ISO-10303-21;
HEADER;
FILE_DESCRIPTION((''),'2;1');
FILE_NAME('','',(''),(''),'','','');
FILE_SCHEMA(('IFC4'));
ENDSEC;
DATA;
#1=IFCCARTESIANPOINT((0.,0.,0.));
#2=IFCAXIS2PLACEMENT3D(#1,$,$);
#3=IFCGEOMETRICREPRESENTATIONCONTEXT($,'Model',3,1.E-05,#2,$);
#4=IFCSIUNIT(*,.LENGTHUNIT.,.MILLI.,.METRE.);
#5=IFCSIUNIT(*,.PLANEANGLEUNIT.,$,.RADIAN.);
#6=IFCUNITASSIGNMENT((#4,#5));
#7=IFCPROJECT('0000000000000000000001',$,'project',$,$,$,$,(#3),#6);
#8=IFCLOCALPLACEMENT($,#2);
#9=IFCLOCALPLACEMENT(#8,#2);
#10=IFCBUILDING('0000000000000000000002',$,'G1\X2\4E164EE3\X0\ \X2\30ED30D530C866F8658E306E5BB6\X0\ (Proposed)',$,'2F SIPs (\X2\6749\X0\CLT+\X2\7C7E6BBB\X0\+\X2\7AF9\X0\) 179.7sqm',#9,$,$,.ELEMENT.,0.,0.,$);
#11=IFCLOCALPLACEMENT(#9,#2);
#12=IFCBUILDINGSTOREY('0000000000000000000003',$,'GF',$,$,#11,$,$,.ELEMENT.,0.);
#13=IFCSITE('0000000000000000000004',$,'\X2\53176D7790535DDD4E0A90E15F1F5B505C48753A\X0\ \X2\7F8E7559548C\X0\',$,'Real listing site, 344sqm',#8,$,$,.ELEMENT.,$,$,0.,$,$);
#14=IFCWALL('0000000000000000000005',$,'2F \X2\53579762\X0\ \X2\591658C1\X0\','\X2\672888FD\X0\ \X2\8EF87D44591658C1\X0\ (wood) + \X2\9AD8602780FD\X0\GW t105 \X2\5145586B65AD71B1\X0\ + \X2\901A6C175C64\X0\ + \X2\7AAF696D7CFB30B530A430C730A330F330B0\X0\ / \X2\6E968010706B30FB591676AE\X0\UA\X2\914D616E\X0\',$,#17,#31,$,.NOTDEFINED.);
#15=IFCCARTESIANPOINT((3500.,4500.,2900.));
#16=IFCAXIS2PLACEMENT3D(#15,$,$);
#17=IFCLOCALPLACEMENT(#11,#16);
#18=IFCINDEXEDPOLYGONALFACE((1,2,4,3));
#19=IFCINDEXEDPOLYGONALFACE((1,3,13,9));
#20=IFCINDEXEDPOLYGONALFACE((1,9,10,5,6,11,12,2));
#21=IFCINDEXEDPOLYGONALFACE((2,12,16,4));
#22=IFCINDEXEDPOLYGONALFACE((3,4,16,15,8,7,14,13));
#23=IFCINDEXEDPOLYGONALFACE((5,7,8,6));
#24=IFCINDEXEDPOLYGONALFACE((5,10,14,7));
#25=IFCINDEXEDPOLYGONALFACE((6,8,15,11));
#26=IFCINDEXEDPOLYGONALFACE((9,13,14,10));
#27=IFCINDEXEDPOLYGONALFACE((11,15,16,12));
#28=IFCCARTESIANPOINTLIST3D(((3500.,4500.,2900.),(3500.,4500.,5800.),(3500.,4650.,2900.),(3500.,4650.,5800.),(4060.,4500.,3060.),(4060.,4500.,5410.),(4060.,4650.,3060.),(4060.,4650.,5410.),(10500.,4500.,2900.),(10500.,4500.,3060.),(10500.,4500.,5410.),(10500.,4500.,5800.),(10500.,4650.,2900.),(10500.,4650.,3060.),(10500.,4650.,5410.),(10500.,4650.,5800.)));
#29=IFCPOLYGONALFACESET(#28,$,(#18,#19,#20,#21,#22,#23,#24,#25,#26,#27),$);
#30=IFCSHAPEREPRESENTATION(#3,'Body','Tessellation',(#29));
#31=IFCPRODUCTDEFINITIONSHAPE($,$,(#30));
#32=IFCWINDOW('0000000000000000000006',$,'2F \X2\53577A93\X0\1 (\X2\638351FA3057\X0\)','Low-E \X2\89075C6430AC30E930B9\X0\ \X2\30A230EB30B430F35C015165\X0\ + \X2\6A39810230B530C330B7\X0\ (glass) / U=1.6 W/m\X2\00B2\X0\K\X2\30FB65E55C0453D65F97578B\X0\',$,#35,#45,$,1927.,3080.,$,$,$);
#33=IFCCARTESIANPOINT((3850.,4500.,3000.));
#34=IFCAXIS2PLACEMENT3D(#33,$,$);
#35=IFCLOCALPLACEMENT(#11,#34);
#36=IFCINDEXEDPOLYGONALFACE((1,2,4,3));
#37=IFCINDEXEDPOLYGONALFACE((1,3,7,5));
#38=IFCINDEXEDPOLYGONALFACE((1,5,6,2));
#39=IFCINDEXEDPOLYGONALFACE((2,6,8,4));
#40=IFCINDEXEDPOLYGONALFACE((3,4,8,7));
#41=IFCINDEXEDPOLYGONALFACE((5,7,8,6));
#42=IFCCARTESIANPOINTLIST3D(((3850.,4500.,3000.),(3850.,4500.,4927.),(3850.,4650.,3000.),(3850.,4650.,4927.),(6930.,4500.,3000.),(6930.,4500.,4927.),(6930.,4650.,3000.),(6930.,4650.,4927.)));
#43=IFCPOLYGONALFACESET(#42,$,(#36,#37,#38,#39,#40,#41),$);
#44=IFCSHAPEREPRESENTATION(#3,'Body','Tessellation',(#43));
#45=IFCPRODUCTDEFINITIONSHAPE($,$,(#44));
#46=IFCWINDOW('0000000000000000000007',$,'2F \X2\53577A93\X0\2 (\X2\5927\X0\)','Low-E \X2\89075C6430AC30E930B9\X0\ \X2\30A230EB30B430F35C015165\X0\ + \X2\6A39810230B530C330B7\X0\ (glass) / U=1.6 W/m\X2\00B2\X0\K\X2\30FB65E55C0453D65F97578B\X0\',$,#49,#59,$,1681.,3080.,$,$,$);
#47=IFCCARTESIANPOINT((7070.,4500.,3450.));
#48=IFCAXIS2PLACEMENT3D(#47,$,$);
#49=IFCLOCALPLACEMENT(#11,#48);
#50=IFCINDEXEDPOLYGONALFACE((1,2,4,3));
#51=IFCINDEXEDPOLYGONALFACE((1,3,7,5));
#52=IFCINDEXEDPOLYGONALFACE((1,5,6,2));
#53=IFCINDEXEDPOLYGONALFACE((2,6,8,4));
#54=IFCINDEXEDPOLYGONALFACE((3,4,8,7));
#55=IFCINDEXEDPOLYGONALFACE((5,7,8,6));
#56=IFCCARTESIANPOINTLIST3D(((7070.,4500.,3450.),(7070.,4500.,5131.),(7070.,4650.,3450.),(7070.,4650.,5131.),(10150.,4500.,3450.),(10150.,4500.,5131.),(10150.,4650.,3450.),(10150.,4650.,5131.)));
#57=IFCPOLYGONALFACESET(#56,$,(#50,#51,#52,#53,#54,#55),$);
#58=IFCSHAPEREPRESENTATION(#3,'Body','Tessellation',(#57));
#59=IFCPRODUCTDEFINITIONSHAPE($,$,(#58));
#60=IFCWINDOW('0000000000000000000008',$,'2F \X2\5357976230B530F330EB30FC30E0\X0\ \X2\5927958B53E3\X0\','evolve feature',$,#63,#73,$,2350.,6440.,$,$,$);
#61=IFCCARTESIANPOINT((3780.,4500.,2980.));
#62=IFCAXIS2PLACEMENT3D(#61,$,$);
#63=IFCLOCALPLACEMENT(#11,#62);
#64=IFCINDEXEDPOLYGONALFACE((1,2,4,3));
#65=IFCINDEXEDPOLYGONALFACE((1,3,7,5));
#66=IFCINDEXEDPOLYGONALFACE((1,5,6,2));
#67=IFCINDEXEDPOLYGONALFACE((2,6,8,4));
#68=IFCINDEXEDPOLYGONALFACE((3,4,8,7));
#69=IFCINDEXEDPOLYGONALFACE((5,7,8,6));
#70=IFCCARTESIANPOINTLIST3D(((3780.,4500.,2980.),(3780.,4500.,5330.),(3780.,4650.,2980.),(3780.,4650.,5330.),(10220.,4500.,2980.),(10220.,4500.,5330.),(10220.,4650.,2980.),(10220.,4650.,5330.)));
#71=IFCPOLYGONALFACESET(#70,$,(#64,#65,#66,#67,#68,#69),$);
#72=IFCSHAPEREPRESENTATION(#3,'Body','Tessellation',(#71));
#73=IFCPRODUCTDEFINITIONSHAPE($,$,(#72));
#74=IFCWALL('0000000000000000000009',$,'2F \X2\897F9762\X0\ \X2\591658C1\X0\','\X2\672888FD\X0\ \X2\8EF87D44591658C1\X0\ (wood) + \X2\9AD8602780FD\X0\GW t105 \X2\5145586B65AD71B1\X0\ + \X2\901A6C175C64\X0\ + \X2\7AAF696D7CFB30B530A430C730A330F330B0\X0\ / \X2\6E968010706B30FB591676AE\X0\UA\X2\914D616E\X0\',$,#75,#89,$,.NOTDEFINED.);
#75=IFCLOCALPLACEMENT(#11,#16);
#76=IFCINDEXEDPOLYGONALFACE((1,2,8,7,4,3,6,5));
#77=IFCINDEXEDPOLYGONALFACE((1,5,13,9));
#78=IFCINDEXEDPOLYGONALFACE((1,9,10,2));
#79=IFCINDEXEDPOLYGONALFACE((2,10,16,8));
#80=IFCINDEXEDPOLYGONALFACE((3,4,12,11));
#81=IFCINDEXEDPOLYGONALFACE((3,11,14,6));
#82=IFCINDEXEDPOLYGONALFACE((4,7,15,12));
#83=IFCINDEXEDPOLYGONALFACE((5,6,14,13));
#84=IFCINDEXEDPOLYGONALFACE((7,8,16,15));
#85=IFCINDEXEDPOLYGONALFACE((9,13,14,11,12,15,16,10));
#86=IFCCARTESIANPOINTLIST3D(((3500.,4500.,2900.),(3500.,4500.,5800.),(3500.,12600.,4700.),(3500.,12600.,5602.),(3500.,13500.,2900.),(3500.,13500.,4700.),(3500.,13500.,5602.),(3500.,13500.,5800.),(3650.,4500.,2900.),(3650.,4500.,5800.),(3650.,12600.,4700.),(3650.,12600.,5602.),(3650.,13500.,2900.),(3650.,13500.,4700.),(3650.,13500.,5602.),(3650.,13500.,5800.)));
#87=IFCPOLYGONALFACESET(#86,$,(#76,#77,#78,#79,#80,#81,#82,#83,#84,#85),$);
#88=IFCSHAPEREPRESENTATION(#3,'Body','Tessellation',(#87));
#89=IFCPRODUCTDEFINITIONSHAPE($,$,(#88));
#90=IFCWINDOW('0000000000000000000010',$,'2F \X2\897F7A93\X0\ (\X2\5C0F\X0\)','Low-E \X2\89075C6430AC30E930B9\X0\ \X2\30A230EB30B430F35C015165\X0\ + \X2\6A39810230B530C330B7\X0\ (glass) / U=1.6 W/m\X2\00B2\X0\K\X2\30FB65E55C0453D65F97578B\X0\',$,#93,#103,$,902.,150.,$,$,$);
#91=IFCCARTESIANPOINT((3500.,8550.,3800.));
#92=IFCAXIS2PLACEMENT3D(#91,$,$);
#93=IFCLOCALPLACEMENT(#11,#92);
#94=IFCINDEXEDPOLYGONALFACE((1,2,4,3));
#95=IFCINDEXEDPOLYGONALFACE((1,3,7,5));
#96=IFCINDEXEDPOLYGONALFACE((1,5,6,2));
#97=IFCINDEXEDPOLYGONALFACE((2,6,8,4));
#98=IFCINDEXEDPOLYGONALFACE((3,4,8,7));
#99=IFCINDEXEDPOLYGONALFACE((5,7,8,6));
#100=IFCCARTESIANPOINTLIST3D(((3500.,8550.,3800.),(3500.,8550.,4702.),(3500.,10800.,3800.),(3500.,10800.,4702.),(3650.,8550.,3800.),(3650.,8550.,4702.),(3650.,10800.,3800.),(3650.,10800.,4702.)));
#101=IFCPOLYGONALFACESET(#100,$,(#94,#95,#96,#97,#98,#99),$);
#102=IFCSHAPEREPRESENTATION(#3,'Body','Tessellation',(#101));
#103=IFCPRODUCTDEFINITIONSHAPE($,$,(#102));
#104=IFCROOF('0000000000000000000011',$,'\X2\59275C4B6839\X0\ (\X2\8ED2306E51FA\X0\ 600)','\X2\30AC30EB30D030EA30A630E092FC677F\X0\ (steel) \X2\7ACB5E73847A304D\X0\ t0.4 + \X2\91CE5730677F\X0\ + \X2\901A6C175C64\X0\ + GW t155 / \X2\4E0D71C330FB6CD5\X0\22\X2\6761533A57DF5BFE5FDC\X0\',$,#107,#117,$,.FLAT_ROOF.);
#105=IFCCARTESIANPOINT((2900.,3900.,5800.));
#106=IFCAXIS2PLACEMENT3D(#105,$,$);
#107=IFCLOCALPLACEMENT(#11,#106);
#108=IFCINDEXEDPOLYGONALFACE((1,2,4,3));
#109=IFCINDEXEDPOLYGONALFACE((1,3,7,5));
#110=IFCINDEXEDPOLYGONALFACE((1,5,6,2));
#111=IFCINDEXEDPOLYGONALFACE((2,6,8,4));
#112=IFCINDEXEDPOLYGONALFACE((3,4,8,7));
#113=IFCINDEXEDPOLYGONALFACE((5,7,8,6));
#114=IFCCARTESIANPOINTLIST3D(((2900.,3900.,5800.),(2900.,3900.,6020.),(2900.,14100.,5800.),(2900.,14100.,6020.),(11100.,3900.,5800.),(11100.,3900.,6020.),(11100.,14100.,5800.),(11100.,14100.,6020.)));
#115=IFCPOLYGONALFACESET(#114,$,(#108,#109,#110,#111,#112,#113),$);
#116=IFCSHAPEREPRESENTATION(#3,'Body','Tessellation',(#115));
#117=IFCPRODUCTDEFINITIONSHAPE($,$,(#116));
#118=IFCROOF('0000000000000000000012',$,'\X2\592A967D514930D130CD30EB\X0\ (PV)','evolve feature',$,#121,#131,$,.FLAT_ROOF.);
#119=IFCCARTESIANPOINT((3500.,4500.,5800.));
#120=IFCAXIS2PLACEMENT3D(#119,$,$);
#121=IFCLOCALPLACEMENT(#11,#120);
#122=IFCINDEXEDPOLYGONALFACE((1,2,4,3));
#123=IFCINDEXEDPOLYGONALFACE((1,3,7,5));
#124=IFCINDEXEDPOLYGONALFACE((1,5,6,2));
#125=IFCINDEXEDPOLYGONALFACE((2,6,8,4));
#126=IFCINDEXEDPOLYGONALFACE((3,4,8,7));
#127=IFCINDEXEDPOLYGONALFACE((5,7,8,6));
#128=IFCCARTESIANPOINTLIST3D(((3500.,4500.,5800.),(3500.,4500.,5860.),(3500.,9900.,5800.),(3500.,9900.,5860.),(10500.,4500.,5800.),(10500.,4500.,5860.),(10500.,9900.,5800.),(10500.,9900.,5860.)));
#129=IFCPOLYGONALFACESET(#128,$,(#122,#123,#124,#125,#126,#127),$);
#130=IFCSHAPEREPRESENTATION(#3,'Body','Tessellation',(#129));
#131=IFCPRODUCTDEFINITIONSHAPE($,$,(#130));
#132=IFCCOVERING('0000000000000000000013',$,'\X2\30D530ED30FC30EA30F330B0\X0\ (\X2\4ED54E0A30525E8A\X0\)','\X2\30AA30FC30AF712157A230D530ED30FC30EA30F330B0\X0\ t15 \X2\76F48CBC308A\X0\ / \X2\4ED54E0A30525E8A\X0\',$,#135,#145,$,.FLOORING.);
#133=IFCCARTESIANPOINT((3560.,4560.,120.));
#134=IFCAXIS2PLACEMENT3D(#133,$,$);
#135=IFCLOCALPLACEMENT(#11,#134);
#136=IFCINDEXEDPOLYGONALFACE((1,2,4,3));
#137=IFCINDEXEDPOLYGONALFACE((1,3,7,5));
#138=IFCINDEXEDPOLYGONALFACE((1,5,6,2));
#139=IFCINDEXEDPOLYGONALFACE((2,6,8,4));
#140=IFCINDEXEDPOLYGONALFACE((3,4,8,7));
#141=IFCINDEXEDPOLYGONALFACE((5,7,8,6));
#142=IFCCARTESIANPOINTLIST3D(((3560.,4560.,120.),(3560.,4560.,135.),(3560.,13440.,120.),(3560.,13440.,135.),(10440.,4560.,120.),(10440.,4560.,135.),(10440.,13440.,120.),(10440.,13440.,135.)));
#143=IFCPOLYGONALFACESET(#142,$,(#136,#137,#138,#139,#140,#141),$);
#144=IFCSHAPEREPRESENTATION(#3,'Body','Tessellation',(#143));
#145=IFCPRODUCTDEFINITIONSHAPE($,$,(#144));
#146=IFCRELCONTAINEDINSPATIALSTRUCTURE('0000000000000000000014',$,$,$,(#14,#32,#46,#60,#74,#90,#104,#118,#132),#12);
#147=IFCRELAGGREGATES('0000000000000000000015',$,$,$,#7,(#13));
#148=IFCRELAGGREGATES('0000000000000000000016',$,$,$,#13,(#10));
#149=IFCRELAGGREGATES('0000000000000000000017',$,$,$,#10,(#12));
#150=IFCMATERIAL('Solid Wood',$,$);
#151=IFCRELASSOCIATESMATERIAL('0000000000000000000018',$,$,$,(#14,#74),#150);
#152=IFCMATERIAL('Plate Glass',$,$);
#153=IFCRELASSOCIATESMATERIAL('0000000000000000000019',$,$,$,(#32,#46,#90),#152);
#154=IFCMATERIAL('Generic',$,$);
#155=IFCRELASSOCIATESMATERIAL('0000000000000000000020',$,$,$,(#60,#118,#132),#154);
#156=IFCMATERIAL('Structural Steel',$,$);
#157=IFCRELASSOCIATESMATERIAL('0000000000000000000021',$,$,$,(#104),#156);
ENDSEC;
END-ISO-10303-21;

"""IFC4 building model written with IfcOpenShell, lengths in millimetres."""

from ifc_helpers import new_model, si_unit, frame, frame_2d, origin, place, context, project, spatial, rectangle, extrude, material, element, fill, save


model = new_model("IFC4")

# Units and contexts
model_context = context("Model", 3, precision=1e-05, world=origin())
ifc_project = project(units=[si_unit("LENGTHUNIT", "METRE", prefix="MILLI"), si_unit("PLANEANGLEUNIT", "RADIAN")], contexts=[model_context])

# Site, building, storey
site_placement = place(None, origin())
site = spatial("IfcSite", under=ifc_project, at=site_placement, Name="北海道川上郡弟子屈町 美留和", ObjectType="Real listing site, 344sqm", CompositionType="ELEMENT", RefElevation=0.0)
building_placement = place(site_placement, origin())
building = spatial("IfcBuilding", under=site, at=building_placement, Name="G1世代 ロフト書斎の家 (Proposed)", ObjectType="2F SIPs (杉CLT+籾殻+竹) 179.7sqm", CompositionType="ELEMENT", ElevationOfRefHeight=0.0, ElevationOfTerrain=0.0)
storey_placement = place(building_placement, origin())
storey = spatial("IfcBuildingStorey", under=building, at=storey_placement, Name="GF", CompositionType="ELEMENT", Elevation=0.0)

# Shared definitions
ifc_material_1 = material(Name="Solid Wood")

# Shared definitions
ifc_material_2 = material(Name="Plate Glass")
ifc_material_3 = material(Name="Generic")

# Wall, openings, windows
wall_1_placement = place(storey_placement, frame((3500.0, 4500.0, 2900.0)))
wall_1 = element("IfcWall", 1, at=wall_1_placement, inside=storey, material=ifc_material_1, Name="2F 南面 外壁", Description="木製 軸組外壁 (wood) + 高性能GW t105 充填断熱 + 通気層 + 窯業系サイディング / 準耐火・外皮UA配慮", PredefinedType="NOTDEFINED", context=model_context, shape_type="SweptSolid", body=[
    extrude(rectangle(XDim=7000.0, YDim=150.0, at=frame_2d((3500.0, 75.0))), frame((3500.0, 4500.0, 2900.0)), (0.0, 0.0, 1.0), 2900.0),
])
opening_1_placement = place(storey_placement, frame((3850.0, 4500.0, 3000.0)))
opening_1 = element("IfcOpeningElement", 2, at=opening_1_placement, cuts=wall_1, PredefinedType="NOTDEFINED", context=model_context, shape_type="SweptSolid", body=[
    extrude(rectangle(XDim=3080.0, YDim=150.0, at=frame_2d((1540.0, 75.0))), frame((3850.0, 4500.0, 3000.0)), (0.0, 0.0, 1.0), 1927.0),
])
opening_2_placement = place(storey_placement, frame((7070.0, 4500.0, 3450.0)))
opening_2 = element("IfcOpeningElement", 3, at=opening_2_placement, cuts=wall_1, PredefinedType="NOTDEFINED", context=model_context, shape_type="SweptSolid", body=[
    extrude(rectangle(XDim=3080.0, YDim=150.0, at=frame_2d((1540.0, 75.0))), frame((7070.0, 4500.0, 3450.0)), (0.0, 0.0, 1.0), 1681.0),
])
opening_3_placement = place(storey_placement, frame((3780.0, 4500.0, 2980.0)))
opening_3 = element("IfcOpeningElement", 4, at=opening_3_placement, cuts=wall_1, PredefinedType="NOTDEFINED", context=model_context, shape_type="SweptSolid", body=[
    extrude(rectangle(XDim=6440.0, YDim=150.0, at=frame_2d((3220.0, 75.0))), frame((3780.0, 4500.0, 2980.0)), (0.0, 0.0, 1.0), 2350.0),
])
window_1_placement = place(storey_placement, frame((3850.0, 4500.0, 3000.0)))
window_1 = element("IfcWindow", 5, at=window_1_placement, inside=storey, material=ifc_material_2, Name="2F 南窓1 (掃出し)", Description="Low-E 複層ガラス アルゴン封入 + 樹脂サッシ (glass) / U=1.6 W/m²K・日射取得型", OverallHeight=1927.0, OverallWidth=3080.0, context=model_context, shape_type="SweptSolid", body=[
    extrude(rectangle(XDim=3080.0, YDim=150.0, at=frame_2d((1540.0, 75.0))), frame((3850.0, 4500.0, 3000.0)), (0.0, 0.0, 1.0), 1927.0),
])
fill(opening_1, window_1)
window_2_placement = place(storey_placement, frame((7070.0, 4500.0, 3450.0)))
window_2 = element("IfcWindow", 6, at=window_2_placement, inside=storey, material=ifc_material_2, Name="2F 南窓2 (大)", Description="Low-E 複層ガラス アルゴン封入 + 樹脂サッシ (glass) / U=1.6 W/m²K・日射取得型", OverallHeight=1681.0, OverallWidth=3080.0, context=model_context, shape_type="SweptSolid", body=[
    extrude(rectangle(XDim=3080.0, YDim=150.0, at=frame_2d((1540.0, 75.0))), frame((7070.0, 4500.0, 3450.0)), (0.0, 0.0, 1.0), 1681.0),
])
fill(opening_2, window_2)
window_3_placement = place(storey_placement, frame((3780.0, 4500.0, 2980.0)))
window_3 = element("IfcWindow", 7, at=window_3_placement, inside=storey, material=ifc_material_3, Name="2F 南面サンルーム 大開口", Description="evolve feature", OverallHeight=2350.0, OverallWidth=6440.0, context=model_context, shape_type="SweptSolid", body=[
    extrude(rectangle(XDim=6440.0, YDim=150.0, at=frame_2d((3220.0, 75.0))), frame((3780.0, 4500.0, 2980.0)), (0.0, 0.0, 1.0), 2350.0),
])
fill(opening_3, window_3)

# Wall, opening, window
wall_2_placement = place(storey_placement, frame((3500.0, 4500.0, 2900.0)))
wall_2 = element("IfcWall", 8, at=wall_2_placement, inside=storey, material=ifc_material_1, Name="2F 西面 外壁", Description="木製 軸組外壁 (wood) + 高性能GW t105 充填断熱 + 通気層 + 窯業系サイディング / 準耐火・外皮UA配慮", PredefinedType="NOTDEFINED", context=model_context, shape_type="SweptSolid", body=[
    extrude(rectangle(XDim=150.0, YDim=9000.0, at=frame_2d((75.0, 4500.0))), frame((3500.0, 4500.0, 2900.0)), (0.0, 0.0, 1.0), 2900.0),
])
opening_4_placement = place(storey_placement, frame((3500.0, 8550.0, 3800.0)))
opening_4 = element("IfcOpeningElement", 9, at=opening_4_placement, cuts=wall_2, PredefinedType="NOTDEFINED", context=model_context, shape_type="SweptSolid", body=[
    extrude(rectangle(XDim=150.0, YDim=2250.0, at=frame_2d((75.0, 1125.0))), frame((3500.0, 8550.0, 3800.0)), (0.0, 0.0, 1.0), 902.0),
])
window_4_placement = place(storey_placement, frame((3500.0, 8550.0, 3800.0)))
window_4 = element("IfcWindow", 10, at=window_4_placement, inside=storey, material=ifc_material_2, Name="2F 西窓 (小)", Description="Low-E 複層ガラス アルゴン封入 + 樹脂サッシ (glass) / U=1.6 W/m²K・日射取得型", OverallHeight=902.0, OverallWidth=150.0, context=model_context, shape_type="SweptSolid", body=[
    extrude(rectangle(XDim=150.0, YDim=2250.0, at=frame_2d((75.0, 1125.0))), frame((3500.0, 8550.0, 3800.0)), (0.0, 0.0, 1.0), 902.0),
])
fill(opening_4, window_4)

# Roofs
ifc_material_4 = material(Name="Structural Steel")
roof_1_placement = place(storey_placement, frame((2900.0, 3900.0, 5800.0)))
element("IfcRoof", 11, at=roof_1_placement, inside=storey, material=ifc_material_4, Name="大屋根 (軒の出 600)", Description="ガルバリウム鋼板 (steel) 立平葺き t0.4 + 野地板 + 通気層 + GW t155 / 不燃・法22条区域対応", PredefinedType="FLAT_ROOF", context=model_context, shape_type="SweptSolid", body=[
    extrude(rectangle(XDim=8200.0, YDim=10200.0, at=frame_2d((4100.0, 5100.0))), frame((2900.0, 3900.0, 5800.0)), (0.0, 0.0, 1.0), 220.0),
])
roof_2_placement = place(storey_placement, frame((3500.0, 4500.0, 5800.0)))
element("IfcRoof", 12, at=roof_2_placement, inside=storey, material=ifc_material_3, Name="太陽光パネル (PV)", Description="evolve feature", PredefinedType="FLAT_ROOF", context=model_context, shape_type="SweptSolid", body=[
    extrude(rectangle(XDim=7000.0, YDim=5400.0, at=frame_2d((3500.0, 2700.0))), frame((3500.0, 4500.0, 5800.0)), (0.0, 0.0, 1.0), 60.0),
])

# Covering
covering_placement = place(storey_placement, frame((3560.0, 4560.0, 120.0)))
element("IfcCovering", 13, at=covering_placement, inside=storey, material=ifc_material_3, Name="フローリング (仕上げ床)", Description="オーク無垢フローリング t15 直貼り / 仕上げ床", PredefinedType="FLOORING", context=model_context, shape_type="SweptSolid", body=[
    extrude(rectangle(XDim=6880.0, YDim=8880.0, at=frame_2d((3440.0, 4440.0))), frame((3560.0, 4560.0, 120.0)), (0.0, 0.0, 1.0), 15.0),
])

save(model, "model.ifc")
